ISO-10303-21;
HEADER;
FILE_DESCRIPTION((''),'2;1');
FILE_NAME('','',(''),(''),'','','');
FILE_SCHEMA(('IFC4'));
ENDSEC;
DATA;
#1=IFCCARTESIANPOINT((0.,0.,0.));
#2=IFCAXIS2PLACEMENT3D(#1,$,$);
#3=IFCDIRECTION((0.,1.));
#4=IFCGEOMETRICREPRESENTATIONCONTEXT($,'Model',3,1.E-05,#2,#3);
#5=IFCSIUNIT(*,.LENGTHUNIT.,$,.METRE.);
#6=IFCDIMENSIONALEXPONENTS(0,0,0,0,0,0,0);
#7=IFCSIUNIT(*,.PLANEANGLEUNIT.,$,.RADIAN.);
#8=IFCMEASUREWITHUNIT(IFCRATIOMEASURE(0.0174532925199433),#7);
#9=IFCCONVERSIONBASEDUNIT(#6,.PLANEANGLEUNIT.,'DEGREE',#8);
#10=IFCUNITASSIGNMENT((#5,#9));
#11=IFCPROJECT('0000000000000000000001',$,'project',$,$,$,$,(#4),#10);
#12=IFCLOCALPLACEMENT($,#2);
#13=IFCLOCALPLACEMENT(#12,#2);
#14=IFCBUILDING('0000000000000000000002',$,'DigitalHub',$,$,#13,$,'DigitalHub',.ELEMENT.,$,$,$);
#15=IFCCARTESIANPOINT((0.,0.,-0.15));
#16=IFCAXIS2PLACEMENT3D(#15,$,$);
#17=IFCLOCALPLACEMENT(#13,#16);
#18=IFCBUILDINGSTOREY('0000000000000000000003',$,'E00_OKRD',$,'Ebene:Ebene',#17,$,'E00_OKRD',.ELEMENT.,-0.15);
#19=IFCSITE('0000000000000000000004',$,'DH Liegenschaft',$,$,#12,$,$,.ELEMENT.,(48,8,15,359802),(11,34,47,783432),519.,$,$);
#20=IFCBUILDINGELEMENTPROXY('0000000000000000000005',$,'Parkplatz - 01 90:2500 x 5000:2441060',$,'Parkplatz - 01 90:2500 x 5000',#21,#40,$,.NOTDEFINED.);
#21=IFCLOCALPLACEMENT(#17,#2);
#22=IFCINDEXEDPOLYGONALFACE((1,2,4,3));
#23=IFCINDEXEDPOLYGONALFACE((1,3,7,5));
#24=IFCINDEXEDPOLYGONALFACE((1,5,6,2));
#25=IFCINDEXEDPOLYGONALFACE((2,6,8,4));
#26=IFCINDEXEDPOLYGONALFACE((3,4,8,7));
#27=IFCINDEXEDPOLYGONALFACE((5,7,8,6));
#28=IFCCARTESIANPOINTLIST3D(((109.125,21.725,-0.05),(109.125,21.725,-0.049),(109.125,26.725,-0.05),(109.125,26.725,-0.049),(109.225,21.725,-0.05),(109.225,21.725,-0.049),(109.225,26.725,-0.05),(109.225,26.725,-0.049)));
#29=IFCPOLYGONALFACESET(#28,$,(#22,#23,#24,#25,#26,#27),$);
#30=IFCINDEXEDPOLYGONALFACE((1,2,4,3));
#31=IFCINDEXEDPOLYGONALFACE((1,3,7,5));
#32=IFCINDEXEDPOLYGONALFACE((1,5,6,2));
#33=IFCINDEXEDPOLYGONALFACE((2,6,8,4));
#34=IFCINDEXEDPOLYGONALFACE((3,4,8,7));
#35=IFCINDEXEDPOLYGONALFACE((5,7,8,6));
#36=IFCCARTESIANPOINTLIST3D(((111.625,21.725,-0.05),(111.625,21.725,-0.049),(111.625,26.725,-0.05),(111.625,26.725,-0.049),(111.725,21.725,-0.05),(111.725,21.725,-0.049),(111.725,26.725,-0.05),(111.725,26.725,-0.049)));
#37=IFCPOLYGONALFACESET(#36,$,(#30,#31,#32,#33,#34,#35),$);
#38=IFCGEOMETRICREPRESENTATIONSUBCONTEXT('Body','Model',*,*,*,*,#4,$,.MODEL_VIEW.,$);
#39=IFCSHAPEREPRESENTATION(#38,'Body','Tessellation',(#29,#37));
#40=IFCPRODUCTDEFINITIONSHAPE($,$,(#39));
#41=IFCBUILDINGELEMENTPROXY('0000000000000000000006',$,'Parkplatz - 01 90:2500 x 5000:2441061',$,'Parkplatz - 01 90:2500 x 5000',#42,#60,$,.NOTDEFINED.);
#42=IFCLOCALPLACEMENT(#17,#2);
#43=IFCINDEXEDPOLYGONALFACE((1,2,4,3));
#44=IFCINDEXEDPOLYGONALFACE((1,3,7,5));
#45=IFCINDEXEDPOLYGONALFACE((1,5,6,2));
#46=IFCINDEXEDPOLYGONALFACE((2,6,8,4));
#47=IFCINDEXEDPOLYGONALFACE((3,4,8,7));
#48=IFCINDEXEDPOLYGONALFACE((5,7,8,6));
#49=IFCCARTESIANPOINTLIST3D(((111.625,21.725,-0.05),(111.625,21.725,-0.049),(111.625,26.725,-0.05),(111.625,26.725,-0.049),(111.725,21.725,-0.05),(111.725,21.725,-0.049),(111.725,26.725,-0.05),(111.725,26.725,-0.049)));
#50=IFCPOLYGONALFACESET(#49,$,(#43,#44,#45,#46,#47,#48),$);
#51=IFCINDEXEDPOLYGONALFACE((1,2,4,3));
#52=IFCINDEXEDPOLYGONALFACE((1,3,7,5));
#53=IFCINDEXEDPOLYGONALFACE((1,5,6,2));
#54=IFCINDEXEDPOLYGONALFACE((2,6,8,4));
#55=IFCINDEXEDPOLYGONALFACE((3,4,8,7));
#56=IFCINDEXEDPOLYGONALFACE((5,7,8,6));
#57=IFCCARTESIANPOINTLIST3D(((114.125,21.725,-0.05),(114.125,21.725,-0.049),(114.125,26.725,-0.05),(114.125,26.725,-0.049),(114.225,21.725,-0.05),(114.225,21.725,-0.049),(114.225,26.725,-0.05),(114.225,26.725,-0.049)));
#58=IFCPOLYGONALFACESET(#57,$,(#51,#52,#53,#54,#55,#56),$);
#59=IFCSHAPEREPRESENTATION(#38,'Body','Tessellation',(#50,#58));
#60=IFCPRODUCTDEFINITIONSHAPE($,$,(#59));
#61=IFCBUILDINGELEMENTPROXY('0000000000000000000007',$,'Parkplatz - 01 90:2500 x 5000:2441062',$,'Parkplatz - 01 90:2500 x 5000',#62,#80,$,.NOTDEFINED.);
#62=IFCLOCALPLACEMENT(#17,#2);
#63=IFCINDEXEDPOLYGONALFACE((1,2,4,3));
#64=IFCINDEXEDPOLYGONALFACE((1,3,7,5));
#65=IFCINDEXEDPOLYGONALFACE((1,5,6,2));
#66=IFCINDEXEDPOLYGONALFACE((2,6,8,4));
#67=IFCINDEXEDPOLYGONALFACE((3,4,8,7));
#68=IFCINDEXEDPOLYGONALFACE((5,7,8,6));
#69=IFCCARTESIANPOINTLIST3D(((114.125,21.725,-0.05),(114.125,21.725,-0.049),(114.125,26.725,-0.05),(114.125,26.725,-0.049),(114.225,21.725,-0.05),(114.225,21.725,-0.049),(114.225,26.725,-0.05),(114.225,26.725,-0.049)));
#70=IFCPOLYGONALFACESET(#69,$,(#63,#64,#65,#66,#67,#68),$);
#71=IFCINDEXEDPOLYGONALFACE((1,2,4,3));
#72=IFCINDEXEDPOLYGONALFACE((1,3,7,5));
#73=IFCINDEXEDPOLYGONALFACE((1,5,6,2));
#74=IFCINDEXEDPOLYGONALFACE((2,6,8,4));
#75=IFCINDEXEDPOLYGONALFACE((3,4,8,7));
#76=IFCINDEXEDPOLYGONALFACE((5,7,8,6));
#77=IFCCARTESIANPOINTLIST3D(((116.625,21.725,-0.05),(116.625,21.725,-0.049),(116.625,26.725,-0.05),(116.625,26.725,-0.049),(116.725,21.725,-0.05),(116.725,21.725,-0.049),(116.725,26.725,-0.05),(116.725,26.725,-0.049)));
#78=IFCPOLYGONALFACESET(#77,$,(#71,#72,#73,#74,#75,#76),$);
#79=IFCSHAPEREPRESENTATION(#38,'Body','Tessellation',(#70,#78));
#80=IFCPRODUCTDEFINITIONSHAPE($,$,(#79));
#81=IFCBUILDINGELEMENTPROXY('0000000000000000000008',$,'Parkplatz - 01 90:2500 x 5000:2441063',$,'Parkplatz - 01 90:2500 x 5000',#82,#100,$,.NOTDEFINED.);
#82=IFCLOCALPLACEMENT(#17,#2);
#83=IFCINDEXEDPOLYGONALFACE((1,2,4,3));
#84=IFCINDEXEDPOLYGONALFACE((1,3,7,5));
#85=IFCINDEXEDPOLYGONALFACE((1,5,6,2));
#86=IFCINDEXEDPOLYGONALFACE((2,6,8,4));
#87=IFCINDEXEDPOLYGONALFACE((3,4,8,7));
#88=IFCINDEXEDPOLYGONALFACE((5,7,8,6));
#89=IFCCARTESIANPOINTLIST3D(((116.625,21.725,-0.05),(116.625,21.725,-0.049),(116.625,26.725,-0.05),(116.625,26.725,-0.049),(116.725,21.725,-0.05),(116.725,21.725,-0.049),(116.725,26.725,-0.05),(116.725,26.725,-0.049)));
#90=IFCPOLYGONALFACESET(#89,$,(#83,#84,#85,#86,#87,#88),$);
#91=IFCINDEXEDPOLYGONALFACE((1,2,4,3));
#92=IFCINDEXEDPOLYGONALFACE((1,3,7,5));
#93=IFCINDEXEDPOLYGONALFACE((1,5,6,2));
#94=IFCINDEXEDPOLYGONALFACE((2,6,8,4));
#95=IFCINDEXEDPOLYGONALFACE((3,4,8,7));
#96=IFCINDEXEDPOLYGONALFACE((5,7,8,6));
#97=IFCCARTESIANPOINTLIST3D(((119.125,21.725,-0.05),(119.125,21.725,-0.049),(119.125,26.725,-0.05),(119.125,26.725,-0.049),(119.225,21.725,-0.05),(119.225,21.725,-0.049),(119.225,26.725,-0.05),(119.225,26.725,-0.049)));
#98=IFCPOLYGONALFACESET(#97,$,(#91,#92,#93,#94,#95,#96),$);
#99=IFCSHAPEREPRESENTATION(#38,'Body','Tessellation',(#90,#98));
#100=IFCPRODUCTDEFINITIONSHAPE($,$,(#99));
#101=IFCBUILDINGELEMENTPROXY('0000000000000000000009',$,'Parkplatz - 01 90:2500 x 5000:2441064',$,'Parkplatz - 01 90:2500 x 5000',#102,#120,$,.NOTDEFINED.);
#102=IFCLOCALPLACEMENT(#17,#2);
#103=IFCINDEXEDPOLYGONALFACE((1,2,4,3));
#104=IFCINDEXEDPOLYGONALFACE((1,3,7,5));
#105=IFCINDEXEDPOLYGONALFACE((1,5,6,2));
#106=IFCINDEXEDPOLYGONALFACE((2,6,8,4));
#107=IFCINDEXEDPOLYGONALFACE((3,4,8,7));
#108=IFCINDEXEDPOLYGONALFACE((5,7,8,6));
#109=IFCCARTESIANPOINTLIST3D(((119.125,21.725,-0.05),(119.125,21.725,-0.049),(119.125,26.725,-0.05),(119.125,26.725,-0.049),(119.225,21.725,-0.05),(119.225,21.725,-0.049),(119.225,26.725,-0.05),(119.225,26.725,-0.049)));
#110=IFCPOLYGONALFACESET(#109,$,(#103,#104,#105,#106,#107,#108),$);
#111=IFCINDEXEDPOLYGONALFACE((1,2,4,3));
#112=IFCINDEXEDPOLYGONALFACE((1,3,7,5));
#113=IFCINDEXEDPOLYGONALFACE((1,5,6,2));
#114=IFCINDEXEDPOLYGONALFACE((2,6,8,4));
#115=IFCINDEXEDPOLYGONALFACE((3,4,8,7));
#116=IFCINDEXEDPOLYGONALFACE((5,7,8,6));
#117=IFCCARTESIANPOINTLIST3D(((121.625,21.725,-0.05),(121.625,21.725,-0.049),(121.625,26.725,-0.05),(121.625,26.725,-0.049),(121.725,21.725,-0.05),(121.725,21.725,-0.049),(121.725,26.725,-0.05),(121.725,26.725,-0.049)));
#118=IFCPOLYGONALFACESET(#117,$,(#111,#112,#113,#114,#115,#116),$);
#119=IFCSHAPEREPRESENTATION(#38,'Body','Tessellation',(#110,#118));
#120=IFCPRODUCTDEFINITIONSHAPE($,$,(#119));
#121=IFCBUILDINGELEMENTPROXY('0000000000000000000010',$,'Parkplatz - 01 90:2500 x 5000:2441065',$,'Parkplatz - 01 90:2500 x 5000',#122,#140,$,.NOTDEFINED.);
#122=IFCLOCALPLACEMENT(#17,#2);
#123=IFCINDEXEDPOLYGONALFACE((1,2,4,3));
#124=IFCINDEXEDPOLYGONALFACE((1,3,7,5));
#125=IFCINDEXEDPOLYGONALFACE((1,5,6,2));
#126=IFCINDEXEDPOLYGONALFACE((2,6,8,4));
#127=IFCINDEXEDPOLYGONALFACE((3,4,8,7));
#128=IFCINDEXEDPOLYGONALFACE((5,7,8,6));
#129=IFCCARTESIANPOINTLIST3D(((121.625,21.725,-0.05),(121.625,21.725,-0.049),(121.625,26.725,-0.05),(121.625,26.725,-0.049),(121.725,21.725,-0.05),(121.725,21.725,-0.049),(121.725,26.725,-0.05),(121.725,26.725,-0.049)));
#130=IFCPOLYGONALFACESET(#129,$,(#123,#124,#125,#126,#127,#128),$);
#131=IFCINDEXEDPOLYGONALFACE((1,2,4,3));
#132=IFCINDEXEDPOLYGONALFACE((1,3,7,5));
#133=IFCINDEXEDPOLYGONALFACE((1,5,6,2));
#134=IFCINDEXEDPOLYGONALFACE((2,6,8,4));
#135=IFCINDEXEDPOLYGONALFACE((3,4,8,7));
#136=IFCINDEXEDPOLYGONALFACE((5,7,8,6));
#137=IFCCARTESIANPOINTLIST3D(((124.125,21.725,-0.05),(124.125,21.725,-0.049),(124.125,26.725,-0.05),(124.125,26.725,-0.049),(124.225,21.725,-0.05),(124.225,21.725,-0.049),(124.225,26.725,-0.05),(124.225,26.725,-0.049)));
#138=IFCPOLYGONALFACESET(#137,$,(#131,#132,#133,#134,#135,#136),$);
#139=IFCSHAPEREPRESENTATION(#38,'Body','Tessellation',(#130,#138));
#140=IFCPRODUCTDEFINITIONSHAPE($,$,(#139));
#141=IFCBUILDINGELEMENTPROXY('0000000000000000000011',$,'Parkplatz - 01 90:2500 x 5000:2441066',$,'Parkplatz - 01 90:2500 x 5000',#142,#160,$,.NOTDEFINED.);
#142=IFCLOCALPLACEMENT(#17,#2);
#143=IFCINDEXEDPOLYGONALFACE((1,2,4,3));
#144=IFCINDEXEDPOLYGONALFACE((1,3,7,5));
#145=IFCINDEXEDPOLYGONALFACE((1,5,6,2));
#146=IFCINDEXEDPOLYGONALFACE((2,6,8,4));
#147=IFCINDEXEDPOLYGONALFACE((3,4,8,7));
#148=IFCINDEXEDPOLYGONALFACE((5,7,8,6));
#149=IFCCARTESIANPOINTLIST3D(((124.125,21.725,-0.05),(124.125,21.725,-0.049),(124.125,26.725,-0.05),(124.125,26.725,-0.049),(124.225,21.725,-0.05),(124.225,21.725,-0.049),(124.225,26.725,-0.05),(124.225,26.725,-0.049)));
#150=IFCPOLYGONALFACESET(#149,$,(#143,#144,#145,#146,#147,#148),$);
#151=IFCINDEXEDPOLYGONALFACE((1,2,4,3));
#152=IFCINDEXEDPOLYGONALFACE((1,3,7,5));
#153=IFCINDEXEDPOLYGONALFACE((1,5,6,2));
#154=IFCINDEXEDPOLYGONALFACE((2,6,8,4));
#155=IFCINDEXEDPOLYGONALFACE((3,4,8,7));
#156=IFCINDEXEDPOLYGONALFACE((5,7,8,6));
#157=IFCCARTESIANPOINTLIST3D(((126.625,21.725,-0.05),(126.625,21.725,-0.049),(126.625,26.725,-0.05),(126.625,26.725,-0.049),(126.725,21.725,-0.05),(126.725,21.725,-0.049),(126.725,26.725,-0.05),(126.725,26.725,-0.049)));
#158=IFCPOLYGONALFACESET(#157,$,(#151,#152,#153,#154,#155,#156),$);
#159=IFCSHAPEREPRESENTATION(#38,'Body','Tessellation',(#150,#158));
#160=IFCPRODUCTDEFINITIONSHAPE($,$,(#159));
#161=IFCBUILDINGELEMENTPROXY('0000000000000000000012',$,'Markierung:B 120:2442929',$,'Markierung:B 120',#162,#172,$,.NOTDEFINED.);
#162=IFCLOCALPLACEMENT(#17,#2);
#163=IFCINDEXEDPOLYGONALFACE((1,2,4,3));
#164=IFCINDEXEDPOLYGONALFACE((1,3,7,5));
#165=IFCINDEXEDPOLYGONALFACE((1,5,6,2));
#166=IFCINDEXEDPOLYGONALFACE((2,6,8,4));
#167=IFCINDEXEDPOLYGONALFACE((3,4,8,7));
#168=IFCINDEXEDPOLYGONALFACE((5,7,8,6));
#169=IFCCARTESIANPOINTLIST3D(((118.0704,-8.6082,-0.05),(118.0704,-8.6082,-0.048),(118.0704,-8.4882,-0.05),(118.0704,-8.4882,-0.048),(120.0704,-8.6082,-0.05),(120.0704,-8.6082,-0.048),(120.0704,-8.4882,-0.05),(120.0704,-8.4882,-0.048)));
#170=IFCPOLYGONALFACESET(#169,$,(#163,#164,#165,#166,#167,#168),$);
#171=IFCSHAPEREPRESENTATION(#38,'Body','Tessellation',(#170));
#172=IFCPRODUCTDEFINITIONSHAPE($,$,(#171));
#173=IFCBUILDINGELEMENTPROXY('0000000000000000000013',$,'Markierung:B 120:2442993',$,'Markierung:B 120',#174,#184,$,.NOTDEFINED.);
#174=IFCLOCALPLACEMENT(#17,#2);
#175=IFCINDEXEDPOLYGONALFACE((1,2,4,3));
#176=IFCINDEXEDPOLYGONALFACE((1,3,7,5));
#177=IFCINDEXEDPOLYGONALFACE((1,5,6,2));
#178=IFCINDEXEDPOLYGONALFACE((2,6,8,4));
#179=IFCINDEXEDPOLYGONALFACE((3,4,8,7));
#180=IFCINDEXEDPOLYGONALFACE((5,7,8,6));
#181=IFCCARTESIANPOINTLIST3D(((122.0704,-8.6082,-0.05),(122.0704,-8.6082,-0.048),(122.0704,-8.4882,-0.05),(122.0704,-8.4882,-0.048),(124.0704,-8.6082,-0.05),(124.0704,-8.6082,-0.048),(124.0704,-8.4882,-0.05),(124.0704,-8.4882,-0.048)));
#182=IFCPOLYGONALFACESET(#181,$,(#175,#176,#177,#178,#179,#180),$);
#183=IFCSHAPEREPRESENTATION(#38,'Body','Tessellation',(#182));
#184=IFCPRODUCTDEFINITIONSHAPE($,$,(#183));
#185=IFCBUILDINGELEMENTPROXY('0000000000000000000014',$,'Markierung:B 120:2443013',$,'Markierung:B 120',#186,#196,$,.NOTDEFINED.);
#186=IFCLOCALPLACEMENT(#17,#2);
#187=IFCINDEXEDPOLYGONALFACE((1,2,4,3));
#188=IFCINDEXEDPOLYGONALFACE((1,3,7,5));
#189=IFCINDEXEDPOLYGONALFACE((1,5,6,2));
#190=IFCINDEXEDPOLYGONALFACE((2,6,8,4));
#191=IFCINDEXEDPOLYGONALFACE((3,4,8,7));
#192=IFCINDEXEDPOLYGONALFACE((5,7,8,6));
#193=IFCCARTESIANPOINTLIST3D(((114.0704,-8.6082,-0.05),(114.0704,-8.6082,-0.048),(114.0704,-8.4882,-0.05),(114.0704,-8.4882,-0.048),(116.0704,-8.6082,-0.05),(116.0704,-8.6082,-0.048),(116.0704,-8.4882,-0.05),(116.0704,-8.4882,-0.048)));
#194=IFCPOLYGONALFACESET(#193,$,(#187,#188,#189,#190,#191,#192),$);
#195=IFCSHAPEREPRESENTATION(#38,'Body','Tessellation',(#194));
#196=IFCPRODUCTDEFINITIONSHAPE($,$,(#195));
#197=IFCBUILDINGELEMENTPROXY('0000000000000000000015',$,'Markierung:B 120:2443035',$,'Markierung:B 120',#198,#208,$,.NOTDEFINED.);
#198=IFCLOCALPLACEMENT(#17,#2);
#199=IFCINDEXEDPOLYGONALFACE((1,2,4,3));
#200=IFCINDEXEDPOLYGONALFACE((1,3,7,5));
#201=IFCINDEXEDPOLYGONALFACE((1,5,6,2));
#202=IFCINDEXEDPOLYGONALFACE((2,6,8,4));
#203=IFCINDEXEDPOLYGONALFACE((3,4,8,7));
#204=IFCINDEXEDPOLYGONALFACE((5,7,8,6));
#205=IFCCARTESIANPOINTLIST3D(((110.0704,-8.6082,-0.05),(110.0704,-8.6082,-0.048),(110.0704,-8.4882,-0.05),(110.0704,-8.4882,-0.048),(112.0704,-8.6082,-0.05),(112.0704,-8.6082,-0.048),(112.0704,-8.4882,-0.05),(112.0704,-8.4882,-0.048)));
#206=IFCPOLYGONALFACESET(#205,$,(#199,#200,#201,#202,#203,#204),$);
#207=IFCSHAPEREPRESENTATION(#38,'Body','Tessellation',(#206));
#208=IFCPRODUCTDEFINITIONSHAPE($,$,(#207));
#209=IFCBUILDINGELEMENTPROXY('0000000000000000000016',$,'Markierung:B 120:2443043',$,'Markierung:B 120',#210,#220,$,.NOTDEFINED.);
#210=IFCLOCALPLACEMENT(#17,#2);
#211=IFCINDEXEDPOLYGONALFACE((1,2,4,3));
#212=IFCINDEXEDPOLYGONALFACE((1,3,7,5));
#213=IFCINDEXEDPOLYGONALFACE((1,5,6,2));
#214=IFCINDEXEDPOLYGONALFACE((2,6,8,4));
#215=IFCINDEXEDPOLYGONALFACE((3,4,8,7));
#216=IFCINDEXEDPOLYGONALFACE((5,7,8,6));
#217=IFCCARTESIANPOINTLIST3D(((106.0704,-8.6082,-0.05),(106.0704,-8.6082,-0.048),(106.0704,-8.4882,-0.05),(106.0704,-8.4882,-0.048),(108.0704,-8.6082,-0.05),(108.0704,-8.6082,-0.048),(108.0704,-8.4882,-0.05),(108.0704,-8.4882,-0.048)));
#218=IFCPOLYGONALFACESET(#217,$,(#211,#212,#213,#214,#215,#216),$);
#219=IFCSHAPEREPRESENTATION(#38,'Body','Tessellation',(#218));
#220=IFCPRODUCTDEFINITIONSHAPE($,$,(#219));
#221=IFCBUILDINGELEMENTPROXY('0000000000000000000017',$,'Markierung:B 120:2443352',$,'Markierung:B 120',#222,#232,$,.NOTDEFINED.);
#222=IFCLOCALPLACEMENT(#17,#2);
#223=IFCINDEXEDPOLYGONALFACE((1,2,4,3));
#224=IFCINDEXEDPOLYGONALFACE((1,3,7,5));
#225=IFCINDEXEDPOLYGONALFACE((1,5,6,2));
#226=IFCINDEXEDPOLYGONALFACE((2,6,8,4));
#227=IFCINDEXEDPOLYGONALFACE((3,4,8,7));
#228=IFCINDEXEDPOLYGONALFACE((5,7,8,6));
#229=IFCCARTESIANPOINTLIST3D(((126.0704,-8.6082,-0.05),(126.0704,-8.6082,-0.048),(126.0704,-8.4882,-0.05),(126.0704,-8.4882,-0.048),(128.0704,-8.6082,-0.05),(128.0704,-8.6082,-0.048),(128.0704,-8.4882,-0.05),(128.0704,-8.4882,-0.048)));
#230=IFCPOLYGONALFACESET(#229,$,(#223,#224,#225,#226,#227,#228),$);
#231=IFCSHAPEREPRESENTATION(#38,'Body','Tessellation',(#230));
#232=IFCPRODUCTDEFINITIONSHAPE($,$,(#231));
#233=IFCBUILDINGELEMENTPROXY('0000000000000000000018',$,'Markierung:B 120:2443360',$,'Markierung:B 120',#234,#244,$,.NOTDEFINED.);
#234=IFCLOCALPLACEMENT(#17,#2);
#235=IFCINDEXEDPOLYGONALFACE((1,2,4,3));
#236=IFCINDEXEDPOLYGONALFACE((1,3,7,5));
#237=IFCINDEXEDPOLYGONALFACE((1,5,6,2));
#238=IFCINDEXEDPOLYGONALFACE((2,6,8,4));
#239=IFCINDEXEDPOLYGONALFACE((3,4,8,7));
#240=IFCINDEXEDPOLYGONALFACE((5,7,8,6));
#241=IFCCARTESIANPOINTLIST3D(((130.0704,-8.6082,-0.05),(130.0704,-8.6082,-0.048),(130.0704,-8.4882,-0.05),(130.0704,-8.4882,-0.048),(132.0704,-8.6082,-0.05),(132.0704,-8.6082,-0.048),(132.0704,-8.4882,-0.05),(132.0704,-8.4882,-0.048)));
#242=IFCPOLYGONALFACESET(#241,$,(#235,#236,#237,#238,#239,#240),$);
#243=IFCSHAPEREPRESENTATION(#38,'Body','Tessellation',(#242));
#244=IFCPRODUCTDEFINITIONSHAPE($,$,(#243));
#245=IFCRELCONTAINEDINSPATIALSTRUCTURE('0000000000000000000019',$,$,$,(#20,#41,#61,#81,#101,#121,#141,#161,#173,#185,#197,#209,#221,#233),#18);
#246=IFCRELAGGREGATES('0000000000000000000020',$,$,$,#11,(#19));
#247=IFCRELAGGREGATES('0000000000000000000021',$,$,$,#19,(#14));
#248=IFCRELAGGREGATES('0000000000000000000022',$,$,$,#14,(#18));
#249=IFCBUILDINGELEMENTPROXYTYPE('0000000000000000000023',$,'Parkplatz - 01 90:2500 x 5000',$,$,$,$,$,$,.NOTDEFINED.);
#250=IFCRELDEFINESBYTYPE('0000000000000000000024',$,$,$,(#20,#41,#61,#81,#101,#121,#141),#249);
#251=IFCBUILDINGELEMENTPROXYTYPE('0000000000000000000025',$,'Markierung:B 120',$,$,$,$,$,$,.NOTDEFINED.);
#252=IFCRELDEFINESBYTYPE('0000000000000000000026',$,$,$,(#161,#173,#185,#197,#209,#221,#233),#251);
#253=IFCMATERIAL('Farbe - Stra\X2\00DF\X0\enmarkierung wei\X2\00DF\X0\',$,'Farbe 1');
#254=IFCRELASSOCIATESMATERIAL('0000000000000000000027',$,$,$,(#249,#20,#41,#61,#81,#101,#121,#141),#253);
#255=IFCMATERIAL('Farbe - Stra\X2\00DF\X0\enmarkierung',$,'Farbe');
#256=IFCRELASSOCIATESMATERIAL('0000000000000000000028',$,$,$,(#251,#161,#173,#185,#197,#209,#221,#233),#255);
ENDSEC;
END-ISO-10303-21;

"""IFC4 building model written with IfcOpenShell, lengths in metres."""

from ifc_helpers import new_model, entity, si_unit, converted_unit, direction, frame, origin, place, context, subcontext, project, spatial, indexed_curve, outline, extrude, source, transform, mapped, material, type_object, type_shapes, element, save


model = new_model("IFC4")

# Units and contexts
model_context = context("Model", 3, precision=1e-05, world=origin(), true_north=direction((0.0, 1.0)))
body_context = subcontext(model_context, "Body", "Model", "MODEL_VIEW")
ifc_project = project(units=[si_unit("LENGTHUNIT", "METRE"), converted_unit("PLANEANGLEUNIT", "DEGREE", entity("IfcRatioMeasure", 0.0174532925199433), si_unit("PLANEANGLEUNIT", "RADIAN"), dimensions=[0, 0, 0, 0, 0, 0, 0])], contexts=[model_context])

# Site, building, storey
site_placement = place(None, frame((0.0, 0.0, 0.0)))
site = spatial("IfcSite", under=ifc_project, at=site_placement, Name="DH Liegenschaft", CompositionType="ELEMENT", RefLatitude=(48, 8, 15, 359802), RefLongitude=(11, 34, 47, 783432), RefElevation=519.0)
building_placement = place(site_placement, origin())
building = spatial("IfcBuilding", under=site, at=building_placement, Name="DigitalHub", LongName="DigitalHub", CompositionType="ELEMENT")
storey_placement = place(building_placement, frame((0.0, 0.0, -0.15)))
storey = spatial("IfcBuildingStorey", under=building, at=storey_placement, Name="E00_OKRD", ObjectType="Ebene:Ebene", LongName="E00_OKRD", CompositionType="ELEMENT", Elevation=-0.15)

# Building element proxies
ifc_material_1 = material(Name="Farbe - Straßenmarkierung weiß", Category="Farbe 1")
building_element_proxy_type_1 = type_object("IfcBuildingElementProxyType", Name="Parkplatz - 01 90:2500 x 5000", PredefinedType="NOTDEFINED", material=ifc_material_1)
shared_shape_1 = source(origin(), body_context, "Body", "SweptSolid", [
    extrude(outline(indexed_curve([(-0.05, -2.5), (0.05, -2.5), (0.05, 2.5), (-0.05, 2.5), (-0.05, -2.5)], self_intersect=False)), frame((2.5456, 2.5, 0.0)), (0.0, 0.0, 1.0), 0.001),
    extrude(outline(indexed_curve([(-2.5, -0.05), (2.5, -0.05), (2.5, 0.05), (-2.5, 0.05), (-2.5, -0.05)], self_intersect=False)), frame((0.0456, 2.5, 0.0), z_axis=(0.0, 0.0, 1.0), x_axis=(0.0, 1.0, 0.0)), (0.0, 0.0, 1.0), 0.001),
])
type_shapes(building_element_proxy_type_1, [shared_shape_1])
for number, where, z_axis, x_axis, name in (
    (1, (111.7206, 26.725, -0.05), (0.0, 0.0, 1.0), (-1.0, 0.0, 0.0), "Parkplatz - 01 90:2500 x 5000:2441060"),
    (2, (114.2206, 26.725, -0.05), (0.0, 0.0, 1.0), (-1.0, 0.0, 0.0), "Parkplatz - 01 90:2500 x 5000:2441061"),
    (3, (116.7206, 26.725, -0.05), (0.0, 0.0, 1.0), (-1.0, 0.0, 0.0), "Parkplatz - 01 90:2500 x 5000:2441062"),
    (4, (119.2206, 26.725, -0.05), (0.0, 0.0, 1.0), (-1.0, 0.0, 0.0), "Parkplatz - 01 90:2500 x 5000:2441063"),
    (5, (121.7206, 26.725, -0.05), (0.0, 0.0, 1.0), (-1.0, 0.0, 0.0), "Parkplatz - 01 90:2500 x 5000:2441064"),
    (6, (124.2206, 26.725, -0.05), (0.0, 0.0, 1.0), (-1.0, 0.0, 0.0), "Parkplatz - 01 90:2500 x 5000:2441065"),
    (7, (126.7206, 26.725, -0.05), (0.0, 0.0, 1.0), (-1.0, 0.0, 0.0), "Parkplatz - 01 90:2500 x 5000:2441066"),
):
    element("IfcBuildingElementProxy", number, at=place(storey_placement, frame(where, z_axis=z_axis, x_axis=x_axis)), inside=storey, type_object=building_element_proxy_type_1, material=ifc_material_1, Name=name, ObjectType="Parkplatz - 01 90:2500 x 5000", PredefinedType="NOTDEFINED", context=body_context, shape_type="MappedRepresentation", body=[
        mapped(shared_shape_1, transform((0.0, 0.0, 0.0), scale=1.0)),
    ])
ifc_material_2 = material(Name="Farbe - Straßenmarkierung", Category="Farbe")
building_element_proxy_type_2 = type_object("IfcBuildingElementProxyType", Name="Markierung:B 120", PredefinedType="NOTDEFINED", material=ifc_material_2)
shared_shape_2 = source(origin(), body_context, "Body", "SweptSolid", [
    extrude(outline(indexed_curve([(-0.06, -1.0), (0.06, -1.0), (0.06, 1.0), (-0.06, 1.0), (-0.06, -1.0)], self_intersect=False)), frame((0.06, 1.0, 0.0), z_axis=(0.0, 0.0, 1.0), x_axis=(-1.0, 0.0, 0.0)), (0.0, 0.0, 1.0), 0.002),
])
type_shapes(building_element_proxy_type_2, [shared_shape_2])
for number, where, z_axis, x_axis, name in (
    (8, (120.0704, -8.6082, -0.05), (0.0, 0.0, 1.0), (0.0, 1.0, 0.0), "Markierung:B 120:2442929"),
    (9, (124.0704, -8.6082, -0.05), (0.0, 0.0, 1.0), (0.0, 1.0, 0.0), "Markierung:B 120:2442993"),
    (10, (116.0704, -8.6082, -0.05), (0.0, 0.0, 1.0), (0.0, 1.0, 0.0), "Markierung:B 120:2443013"),
    (11, (112.0704, -8.6082, -0.05), (0.0, 0.0, 1.0), (0.0, 1.0, 0.0), "Markierung:B 120:2443035"),
    (12, (108.0704, -8.6082, -0.05), (0.0, 0.0, 1.0), (0.0, 1.0, 0.0), "Markierung:B 120:2443043"),
    (13, (128.0704, -8.6082, -0.05), (0.0, 0.0, 1.0), (0.0, 1.0, 0.0), "Markierung:B 120:2443352"),
    (14, (132.0704, -8.6082, -0.05), (0.0, 0.0, 1.0), (0.0, 1.0, 0.0), "Markierung:B 120:2443360"),
):
    element("IfcBuildingElementProxy", number, at=place(storey_placement, frame(where, z_axis=z_axis, x_axis=x_axis)), inside=storey, type_object=building_element_proxy_type_2, material=ifc_material_2, Name=name, ObjectType="Markierung:B 120", PredefinedType="NOTDEFINED", context=body_context, shape_type="MappedRepresentation", body=[
        mapped(shared_shape_2, transform((0.0, 0.0, 0.0), scale=1.0)),
    ])

save(model, "model.ifc")
